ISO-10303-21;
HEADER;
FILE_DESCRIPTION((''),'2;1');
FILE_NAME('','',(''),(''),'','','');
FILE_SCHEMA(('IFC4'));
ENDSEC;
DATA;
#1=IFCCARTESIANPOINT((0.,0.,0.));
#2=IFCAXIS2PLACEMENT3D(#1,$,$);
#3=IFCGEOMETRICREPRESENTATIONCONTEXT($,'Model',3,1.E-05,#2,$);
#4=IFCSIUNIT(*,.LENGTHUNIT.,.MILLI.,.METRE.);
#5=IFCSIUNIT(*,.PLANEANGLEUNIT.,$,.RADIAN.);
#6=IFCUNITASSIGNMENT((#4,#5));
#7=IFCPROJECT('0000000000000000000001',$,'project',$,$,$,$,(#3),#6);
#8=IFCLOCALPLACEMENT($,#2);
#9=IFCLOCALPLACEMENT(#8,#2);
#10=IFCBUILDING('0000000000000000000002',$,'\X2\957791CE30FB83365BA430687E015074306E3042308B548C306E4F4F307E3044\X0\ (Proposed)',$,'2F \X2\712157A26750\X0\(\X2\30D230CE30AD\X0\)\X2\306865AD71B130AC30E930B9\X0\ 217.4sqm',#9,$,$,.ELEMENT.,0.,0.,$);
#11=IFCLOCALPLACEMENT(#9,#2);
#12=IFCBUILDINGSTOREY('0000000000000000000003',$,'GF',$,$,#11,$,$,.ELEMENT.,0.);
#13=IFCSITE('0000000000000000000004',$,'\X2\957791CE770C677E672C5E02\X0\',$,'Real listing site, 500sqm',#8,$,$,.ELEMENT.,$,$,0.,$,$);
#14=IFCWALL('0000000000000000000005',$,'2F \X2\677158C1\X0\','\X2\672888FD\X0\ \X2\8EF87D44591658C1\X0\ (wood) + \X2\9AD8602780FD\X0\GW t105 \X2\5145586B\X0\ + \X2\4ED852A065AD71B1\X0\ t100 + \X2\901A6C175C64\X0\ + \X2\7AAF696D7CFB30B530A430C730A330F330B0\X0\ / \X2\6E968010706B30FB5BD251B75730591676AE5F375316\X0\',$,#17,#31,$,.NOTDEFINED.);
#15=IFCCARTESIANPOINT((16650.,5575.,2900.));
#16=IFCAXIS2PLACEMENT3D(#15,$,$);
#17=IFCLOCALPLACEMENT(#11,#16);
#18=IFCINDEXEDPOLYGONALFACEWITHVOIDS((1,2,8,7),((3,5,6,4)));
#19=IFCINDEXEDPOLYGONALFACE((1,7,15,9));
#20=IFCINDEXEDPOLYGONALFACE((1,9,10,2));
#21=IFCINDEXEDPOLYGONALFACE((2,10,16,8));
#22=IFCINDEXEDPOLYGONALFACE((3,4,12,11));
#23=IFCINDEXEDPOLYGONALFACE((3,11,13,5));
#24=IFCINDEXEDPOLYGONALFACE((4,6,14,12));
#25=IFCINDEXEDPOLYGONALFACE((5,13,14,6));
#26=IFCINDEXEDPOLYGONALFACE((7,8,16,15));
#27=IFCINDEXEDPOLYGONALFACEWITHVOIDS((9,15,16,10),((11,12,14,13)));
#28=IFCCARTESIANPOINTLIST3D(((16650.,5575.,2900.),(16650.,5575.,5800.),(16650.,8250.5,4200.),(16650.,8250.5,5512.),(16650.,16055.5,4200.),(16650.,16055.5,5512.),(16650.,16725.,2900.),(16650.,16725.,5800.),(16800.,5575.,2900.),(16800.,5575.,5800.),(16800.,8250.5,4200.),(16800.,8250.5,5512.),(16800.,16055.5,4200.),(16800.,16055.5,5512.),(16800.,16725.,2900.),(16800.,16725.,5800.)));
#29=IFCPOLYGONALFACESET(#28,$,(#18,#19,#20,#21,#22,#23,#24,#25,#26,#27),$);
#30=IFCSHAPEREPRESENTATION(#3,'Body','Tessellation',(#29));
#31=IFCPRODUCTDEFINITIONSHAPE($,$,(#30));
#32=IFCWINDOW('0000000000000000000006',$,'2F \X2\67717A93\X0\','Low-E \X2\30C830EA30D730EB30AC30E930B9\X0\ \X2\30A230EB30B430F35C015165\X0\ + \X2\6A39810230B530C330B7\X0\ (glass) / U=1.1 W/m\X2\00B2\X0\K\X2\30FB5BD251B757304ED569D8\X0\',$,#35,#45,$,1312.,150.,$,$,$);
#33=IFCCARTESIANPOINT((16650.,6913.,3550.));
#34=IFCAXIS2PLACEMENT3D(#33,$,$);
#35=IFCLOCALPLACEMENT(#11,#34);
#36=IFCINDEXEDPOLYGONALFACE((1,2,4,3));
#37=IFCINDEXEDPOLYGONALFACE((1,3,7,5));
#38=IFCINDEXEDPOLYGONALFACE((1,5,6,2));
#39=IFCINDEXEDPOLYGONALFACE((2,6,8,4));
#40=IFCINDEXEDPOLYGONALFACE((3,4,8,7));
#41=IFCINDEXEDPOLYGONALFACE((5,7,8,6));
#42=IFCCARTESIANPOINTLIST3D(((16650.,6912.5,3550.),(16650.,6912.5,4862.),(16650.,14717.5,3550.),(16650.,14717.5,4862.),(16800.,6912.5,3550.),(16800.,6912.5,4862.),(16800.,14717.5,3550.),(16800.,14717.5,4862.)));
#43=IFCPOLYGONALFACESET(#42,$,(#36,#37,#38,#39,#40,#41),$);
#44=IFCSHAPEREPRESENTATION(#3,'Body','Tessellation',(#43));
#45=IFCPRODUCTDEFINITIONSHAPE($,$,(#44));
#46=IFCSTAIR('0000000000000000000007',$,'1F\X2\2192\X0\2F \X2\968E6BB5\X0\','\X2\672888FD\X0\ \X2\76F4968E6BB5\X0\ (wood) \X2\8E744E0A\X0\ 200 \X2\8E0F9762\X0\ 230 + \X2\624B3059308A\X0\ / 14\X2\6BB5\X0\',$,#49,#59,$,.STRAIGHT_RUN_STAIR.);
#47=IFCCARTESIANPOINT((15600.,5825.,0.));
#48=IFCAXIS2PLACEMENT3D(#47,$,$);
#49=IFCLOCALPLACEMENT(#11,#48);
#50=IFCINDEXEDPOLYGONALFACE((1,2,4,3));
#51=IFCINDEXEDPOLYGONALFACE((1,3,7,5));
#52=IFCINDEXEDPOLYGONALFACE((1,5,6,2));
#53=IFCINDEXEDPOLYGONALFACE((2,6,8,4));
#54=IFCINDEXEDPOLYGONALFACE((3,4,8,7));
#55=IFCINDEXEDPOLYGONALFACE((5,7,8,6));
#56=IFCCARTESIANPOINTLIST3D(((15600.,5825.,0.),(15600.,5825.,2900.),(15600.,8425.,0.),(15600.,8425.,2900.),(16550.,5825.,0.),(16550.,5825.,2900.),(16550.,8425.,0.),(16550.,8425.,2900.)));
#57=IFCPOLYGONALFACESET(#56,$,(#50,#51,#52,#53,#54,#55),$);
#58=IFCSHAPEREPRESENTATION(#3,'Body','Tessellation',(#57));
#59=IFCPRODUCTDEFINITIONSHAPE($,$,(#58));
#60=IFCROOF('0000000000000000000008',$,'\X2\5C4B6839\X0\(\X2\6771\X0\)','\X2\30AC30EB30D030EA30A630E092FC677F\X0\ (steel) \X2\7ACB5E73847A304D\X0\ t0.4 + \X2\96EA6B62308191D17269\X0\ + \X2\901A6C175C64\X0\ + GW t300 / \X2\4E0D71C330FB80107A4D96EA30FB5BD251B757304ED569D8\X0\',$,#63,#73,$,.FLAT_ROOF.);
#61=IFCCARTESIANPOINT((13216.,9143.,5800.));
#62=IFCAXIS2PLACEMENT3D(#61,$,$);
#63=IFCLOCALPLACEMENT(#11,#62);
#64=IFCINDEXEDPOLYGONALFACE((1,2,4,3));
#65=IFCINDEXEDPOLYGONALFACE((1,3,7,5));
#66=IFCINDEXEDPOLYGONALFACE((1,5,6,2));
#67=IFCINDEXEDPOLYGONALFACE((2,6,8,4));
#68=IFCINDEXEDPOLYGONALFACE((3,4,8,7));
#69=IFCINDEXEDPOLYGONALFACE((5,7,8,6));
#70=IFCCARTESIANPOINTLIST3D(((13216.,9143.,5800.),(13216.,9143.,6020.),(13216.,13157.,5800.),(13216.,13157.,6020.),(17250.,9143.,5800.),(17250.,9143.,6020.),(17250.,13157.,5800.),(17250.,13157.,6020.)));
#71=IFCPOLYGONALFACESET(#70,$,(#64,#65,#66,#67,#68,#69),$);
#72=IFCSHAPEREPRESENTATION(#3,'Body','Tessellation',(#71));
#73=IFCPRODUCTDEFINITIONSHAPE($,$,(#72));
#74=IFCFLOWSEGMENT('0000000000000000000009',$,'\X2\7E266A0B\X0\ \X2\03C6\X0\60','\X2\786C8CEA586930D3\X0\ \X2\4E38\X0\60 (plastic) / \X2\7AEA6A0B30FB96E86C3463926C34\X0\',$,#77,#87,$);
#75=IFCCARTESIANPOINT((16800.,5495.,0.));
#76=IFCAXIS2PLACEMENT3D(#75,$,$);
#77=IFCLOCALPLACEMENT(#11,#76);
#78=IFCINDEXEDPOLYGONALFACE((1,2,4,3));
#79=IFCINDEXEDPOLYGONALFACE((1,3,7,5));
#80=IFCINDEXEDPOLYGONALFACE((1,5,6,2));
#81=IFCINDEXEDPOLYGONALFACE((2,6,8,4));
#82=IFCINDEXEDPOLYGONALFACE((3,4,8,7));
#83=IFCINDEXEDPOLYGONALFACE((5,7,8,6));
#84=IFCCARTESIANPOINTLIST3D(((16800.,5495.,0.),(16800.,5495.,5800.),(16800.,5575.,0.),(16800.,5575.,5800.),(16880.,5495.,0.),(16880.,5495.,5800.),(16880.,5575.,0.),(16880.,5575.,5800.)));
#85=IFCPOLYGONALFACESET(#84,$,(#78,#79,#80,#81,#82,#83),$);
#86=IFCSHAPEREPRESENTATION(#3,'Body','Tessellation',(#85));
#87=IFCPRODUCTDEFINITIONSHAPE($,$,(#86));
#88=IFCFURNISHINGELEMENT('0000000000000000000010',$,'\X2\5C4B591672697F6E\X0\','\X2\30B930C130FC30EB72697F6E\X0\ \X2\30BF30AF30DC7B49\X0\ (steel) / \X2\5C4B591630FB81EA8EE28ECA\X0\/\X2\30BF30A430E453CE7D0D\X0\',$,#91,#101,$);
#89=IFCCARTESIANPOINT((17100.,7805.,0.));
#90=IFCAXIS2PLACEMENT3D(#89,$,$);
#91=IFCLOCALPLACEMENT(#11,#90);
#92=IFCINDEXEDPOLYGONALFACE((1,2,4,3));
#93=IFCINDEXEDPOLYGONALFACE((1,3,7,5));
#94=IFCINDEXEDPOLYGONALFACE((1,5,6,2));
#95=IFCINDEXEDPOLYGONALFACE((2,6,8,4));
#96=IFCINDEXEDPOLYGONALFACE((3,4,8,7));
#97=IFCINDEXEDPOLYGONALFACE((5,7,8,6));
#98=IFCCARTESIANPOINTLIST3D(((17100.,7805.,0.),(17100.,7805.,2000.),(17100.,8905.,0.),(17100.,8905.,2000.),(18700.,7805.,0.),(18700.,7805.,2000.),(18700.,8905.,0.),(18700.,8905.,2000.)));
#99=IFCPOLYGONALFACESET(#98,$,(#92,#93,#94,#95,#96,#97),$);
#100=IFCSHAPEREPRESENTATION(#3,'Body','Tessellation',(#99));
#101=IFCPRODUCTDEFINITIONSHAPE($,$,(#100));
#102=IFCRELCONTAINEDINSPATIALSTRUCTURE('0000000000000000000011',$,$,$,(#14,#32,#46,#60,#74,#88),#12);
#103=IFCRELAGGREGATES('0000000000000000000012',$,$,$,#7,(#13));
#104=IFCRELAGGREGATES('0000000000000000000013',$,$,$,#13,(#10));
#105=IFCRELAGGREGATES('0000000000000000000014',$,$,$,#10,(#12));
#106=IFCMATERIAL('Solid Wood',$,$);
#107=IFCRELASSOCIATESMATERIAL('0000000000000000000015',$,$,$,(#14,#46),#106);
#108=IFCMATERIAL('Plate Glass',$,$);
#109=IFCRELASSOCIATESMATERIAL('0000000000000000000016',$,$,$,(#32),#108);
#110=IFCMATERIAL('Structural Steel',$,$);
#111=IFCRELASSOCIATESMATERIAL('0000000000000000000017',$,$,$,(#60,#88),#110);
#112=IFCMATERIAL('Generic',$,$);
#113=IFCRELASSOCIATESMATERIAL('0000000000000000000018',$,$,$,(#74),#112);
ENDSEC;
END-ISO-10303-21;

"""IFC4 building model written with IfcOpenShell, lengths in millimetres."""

from ifc_helpers import new_model, si_unit, frame, frame_2d, origin, place, context, project, spatial, rectangle, extrude, material, element, fill, save


model = new_model("IFC4")

# Units and contexts
model_context = context("Model", 3, precision=1e-05, world=origin())
ifc_project = project(units=[si_unit("LENGTHUNIT", "METRE", prefix="MILLI"), si_unit("PLANEANGLEUNIT", "RADIAN")], contexts=[model_context])

# Site, building, storey
site_placement = place(None, origin())
site = spatial("IfcSite", under=ifc_project, at=site_placement, Name="長野県松本市", ObjectType="Real listing site, 500sqm", CompositionType="ELEMENT", RefElevation=0.0)
building_placement = place(site_placement, origin())
building = spatial("IfcBuilding", under=site, at=building_placement, Name="長野・茶室と縁側のある和の住まい (Proposed)", ObjectType="2F 無垢材(ヒノキ)と断熱ガラス 217.4sqm", CompositionType="ELEMENT", ElevationOfRefHeight=0.0, ElevationOfTerrain=0.0)
storey_placement = place(building_placement, origin())
storey = spatial("IfcBuildingStorey", under=building, at=storey_placement, Name="GF", CompositionType="ELEMENT", Elevation=0.0)

# Shared definitions
ifc_material_1 = material(Name="Solid Wood")

# Wall, opening, window
ifc_material_2 = material(Name="Plate Glass")
wall_1_placement = place(storey_placement, frame((16650.0, 5575.0, 2900.0)))
wall_1 = element("IfcWall", 1, at=wall_1_placement, inside=storey, material=ifc_material_1, Name="2F 東壁", Description="木製 軸組外壁 (wood) + 高性能GW t105 充填 + 付加断熱 t100 + 通気層 + 窯業系サイディング / 準耐火・寒冷地外皮強化", PredefinedType="NOTDEFINED", context=model_context, shape_type="SweptSolid", body=[
    extrude(rectangle(XDim=150.0, YDim=11150.0, at=frame_2d((75.0, 5575.0))), frame((16650.0, 5575.0, 2900.0)), (0.0, 0.0, 1.0), 2900.0),
])
opening_1_placement = place(storey_placement, frame((16650.0, 6913.0, 3550.0)))
opening_1 = element("IfcOpeningElement", 2, at=opening_1_placement, cuts=wall_1, PredefinedType="NOTDEFINED", context=model_context, shape_type="SweptSolid", body=[
    extrude(rectangle(XDim=150.0, YDim=7805.0, at=frame_2d((75.0, 3902.0))), frame((16650.0, 6913.0, 3550.0)), (0.0, 0.0, 1.0), 1312.0),
])
window_1_placement = place(storey_placement, frame((16650.0, 6913.0, 3550.0)))
window_1 = element("IfcWindow", 3, at=window_1_placement, inside=storey, material=ifc_material_2, Name="2F 東窓", Description="Low-E トリプルガラス アルゴン封入 + 樹脂サッシ (glass) / U=1.1 W/m²K・寒冷地仕様", OverallHeight=1312.0, OverallWidth=150.0, context=model_context, shape_type="SweptSolid", body=[
    extrude(rectangle(XDim=150.0, YDim=7805.0, at=frame_2d((75.0, 3902.0))), frame((16650.0, 6913.0, 3550.0)), (0.0, 0.0, 1.0), 1312.0),
])
fill(opening_1, window_1)

# Stair
stair_placement = place(storey_placement, frame((15600.0, 5825.0, 0.0)))
element("IfcStair", 4, at=stair_placement, inside=storey, material=ifc_material_1, Name="1F→2F 階段", Description="木製 直階段 (wood) 蹴上 200 踏面 230 + 手すり / 14段", PredefinedType="STRAIGHT_RUN_STAIR", context=model_context, shape_type="SweptSolid", body=[
    extrude(rectangle(XDim=950.0, YDim=2600.0, at=frame_2d((475.0, 1300.0))), frame((15600.0, 5825.0, 0.0)), (0.0, 0.0, 1.0), 2900.0),
])

# Roof
ifc_material_3 = material(Name="Structural Steel")
roof_placement = place(storey_placement, frame((13216.0, 9143.0, 5800.0)))
element("IfcRoof", 5, at=roof_placement, inside=storey, material=ifc_material_3, Name="屋根(東)", Description="ガルバリウム鋼板 (steel) 立平葺き t0.4 + 雪止め金物 + 通気層 + GW t300 / 不燃・耐積雪・寒冷地仕様", PredefinedType="FLAT_ROOF", context=model_context, shape_type="SweptSolid", body=[
    extrude(rectangle(XDim=4034.0, YDim=4014.0, at=frame_2d((2017.0, 2007.0))), frame((13216.0, 9143.0, 5800.0)), (0.0, 0.0, 1.0), 220.0),
])

# Flow segment
ifc_material_4 = material(Name="Generic")
flow_segment_placement = place(storey_placement, frame((16800.0, 5495.0, 0.0)))
element("IfcFlowSegment", 6, at=flow_segment_placement, inside=storey, material=ifc_material_4, Name="縦樋 φ60", Description="硬質塩ビ 丸60 (plastic) / 竪樋・雨水排水", context=model_context, shape_type="SweptSolid", body=[
    extrude(rectangle(XDim=80.0, YDim=80.0, at=frame_2d((40.0, 40.0))), frame((16800.0, 5495.0, 0.0)), (0.0, 0.0, 1.0), 5800.0),
])

# Furnishing element
furnishing_placement = place(storey_placement, frame((17100.0, 7805.0, 0.0)))
element("IfcFurnishingElement", 7, at=furnishing_placement, inside=storey, material=ifc_material_3, Name="屋外物置", Description="スチール物置 タクボ等 (steel) / 屋外・自転車/タイヤ収納", context=model_context, shape_type="SweptSolid", body=[
    extrude(rectangle(XDim=1600.0, YDim=1100.0, at=frame_2d((800.0, 550.0))), frame((17100.0, 7805.0, 0.0)), (0.0, 0.0, 1.0), 2000.0),
])

save(model, "model.ifc")
